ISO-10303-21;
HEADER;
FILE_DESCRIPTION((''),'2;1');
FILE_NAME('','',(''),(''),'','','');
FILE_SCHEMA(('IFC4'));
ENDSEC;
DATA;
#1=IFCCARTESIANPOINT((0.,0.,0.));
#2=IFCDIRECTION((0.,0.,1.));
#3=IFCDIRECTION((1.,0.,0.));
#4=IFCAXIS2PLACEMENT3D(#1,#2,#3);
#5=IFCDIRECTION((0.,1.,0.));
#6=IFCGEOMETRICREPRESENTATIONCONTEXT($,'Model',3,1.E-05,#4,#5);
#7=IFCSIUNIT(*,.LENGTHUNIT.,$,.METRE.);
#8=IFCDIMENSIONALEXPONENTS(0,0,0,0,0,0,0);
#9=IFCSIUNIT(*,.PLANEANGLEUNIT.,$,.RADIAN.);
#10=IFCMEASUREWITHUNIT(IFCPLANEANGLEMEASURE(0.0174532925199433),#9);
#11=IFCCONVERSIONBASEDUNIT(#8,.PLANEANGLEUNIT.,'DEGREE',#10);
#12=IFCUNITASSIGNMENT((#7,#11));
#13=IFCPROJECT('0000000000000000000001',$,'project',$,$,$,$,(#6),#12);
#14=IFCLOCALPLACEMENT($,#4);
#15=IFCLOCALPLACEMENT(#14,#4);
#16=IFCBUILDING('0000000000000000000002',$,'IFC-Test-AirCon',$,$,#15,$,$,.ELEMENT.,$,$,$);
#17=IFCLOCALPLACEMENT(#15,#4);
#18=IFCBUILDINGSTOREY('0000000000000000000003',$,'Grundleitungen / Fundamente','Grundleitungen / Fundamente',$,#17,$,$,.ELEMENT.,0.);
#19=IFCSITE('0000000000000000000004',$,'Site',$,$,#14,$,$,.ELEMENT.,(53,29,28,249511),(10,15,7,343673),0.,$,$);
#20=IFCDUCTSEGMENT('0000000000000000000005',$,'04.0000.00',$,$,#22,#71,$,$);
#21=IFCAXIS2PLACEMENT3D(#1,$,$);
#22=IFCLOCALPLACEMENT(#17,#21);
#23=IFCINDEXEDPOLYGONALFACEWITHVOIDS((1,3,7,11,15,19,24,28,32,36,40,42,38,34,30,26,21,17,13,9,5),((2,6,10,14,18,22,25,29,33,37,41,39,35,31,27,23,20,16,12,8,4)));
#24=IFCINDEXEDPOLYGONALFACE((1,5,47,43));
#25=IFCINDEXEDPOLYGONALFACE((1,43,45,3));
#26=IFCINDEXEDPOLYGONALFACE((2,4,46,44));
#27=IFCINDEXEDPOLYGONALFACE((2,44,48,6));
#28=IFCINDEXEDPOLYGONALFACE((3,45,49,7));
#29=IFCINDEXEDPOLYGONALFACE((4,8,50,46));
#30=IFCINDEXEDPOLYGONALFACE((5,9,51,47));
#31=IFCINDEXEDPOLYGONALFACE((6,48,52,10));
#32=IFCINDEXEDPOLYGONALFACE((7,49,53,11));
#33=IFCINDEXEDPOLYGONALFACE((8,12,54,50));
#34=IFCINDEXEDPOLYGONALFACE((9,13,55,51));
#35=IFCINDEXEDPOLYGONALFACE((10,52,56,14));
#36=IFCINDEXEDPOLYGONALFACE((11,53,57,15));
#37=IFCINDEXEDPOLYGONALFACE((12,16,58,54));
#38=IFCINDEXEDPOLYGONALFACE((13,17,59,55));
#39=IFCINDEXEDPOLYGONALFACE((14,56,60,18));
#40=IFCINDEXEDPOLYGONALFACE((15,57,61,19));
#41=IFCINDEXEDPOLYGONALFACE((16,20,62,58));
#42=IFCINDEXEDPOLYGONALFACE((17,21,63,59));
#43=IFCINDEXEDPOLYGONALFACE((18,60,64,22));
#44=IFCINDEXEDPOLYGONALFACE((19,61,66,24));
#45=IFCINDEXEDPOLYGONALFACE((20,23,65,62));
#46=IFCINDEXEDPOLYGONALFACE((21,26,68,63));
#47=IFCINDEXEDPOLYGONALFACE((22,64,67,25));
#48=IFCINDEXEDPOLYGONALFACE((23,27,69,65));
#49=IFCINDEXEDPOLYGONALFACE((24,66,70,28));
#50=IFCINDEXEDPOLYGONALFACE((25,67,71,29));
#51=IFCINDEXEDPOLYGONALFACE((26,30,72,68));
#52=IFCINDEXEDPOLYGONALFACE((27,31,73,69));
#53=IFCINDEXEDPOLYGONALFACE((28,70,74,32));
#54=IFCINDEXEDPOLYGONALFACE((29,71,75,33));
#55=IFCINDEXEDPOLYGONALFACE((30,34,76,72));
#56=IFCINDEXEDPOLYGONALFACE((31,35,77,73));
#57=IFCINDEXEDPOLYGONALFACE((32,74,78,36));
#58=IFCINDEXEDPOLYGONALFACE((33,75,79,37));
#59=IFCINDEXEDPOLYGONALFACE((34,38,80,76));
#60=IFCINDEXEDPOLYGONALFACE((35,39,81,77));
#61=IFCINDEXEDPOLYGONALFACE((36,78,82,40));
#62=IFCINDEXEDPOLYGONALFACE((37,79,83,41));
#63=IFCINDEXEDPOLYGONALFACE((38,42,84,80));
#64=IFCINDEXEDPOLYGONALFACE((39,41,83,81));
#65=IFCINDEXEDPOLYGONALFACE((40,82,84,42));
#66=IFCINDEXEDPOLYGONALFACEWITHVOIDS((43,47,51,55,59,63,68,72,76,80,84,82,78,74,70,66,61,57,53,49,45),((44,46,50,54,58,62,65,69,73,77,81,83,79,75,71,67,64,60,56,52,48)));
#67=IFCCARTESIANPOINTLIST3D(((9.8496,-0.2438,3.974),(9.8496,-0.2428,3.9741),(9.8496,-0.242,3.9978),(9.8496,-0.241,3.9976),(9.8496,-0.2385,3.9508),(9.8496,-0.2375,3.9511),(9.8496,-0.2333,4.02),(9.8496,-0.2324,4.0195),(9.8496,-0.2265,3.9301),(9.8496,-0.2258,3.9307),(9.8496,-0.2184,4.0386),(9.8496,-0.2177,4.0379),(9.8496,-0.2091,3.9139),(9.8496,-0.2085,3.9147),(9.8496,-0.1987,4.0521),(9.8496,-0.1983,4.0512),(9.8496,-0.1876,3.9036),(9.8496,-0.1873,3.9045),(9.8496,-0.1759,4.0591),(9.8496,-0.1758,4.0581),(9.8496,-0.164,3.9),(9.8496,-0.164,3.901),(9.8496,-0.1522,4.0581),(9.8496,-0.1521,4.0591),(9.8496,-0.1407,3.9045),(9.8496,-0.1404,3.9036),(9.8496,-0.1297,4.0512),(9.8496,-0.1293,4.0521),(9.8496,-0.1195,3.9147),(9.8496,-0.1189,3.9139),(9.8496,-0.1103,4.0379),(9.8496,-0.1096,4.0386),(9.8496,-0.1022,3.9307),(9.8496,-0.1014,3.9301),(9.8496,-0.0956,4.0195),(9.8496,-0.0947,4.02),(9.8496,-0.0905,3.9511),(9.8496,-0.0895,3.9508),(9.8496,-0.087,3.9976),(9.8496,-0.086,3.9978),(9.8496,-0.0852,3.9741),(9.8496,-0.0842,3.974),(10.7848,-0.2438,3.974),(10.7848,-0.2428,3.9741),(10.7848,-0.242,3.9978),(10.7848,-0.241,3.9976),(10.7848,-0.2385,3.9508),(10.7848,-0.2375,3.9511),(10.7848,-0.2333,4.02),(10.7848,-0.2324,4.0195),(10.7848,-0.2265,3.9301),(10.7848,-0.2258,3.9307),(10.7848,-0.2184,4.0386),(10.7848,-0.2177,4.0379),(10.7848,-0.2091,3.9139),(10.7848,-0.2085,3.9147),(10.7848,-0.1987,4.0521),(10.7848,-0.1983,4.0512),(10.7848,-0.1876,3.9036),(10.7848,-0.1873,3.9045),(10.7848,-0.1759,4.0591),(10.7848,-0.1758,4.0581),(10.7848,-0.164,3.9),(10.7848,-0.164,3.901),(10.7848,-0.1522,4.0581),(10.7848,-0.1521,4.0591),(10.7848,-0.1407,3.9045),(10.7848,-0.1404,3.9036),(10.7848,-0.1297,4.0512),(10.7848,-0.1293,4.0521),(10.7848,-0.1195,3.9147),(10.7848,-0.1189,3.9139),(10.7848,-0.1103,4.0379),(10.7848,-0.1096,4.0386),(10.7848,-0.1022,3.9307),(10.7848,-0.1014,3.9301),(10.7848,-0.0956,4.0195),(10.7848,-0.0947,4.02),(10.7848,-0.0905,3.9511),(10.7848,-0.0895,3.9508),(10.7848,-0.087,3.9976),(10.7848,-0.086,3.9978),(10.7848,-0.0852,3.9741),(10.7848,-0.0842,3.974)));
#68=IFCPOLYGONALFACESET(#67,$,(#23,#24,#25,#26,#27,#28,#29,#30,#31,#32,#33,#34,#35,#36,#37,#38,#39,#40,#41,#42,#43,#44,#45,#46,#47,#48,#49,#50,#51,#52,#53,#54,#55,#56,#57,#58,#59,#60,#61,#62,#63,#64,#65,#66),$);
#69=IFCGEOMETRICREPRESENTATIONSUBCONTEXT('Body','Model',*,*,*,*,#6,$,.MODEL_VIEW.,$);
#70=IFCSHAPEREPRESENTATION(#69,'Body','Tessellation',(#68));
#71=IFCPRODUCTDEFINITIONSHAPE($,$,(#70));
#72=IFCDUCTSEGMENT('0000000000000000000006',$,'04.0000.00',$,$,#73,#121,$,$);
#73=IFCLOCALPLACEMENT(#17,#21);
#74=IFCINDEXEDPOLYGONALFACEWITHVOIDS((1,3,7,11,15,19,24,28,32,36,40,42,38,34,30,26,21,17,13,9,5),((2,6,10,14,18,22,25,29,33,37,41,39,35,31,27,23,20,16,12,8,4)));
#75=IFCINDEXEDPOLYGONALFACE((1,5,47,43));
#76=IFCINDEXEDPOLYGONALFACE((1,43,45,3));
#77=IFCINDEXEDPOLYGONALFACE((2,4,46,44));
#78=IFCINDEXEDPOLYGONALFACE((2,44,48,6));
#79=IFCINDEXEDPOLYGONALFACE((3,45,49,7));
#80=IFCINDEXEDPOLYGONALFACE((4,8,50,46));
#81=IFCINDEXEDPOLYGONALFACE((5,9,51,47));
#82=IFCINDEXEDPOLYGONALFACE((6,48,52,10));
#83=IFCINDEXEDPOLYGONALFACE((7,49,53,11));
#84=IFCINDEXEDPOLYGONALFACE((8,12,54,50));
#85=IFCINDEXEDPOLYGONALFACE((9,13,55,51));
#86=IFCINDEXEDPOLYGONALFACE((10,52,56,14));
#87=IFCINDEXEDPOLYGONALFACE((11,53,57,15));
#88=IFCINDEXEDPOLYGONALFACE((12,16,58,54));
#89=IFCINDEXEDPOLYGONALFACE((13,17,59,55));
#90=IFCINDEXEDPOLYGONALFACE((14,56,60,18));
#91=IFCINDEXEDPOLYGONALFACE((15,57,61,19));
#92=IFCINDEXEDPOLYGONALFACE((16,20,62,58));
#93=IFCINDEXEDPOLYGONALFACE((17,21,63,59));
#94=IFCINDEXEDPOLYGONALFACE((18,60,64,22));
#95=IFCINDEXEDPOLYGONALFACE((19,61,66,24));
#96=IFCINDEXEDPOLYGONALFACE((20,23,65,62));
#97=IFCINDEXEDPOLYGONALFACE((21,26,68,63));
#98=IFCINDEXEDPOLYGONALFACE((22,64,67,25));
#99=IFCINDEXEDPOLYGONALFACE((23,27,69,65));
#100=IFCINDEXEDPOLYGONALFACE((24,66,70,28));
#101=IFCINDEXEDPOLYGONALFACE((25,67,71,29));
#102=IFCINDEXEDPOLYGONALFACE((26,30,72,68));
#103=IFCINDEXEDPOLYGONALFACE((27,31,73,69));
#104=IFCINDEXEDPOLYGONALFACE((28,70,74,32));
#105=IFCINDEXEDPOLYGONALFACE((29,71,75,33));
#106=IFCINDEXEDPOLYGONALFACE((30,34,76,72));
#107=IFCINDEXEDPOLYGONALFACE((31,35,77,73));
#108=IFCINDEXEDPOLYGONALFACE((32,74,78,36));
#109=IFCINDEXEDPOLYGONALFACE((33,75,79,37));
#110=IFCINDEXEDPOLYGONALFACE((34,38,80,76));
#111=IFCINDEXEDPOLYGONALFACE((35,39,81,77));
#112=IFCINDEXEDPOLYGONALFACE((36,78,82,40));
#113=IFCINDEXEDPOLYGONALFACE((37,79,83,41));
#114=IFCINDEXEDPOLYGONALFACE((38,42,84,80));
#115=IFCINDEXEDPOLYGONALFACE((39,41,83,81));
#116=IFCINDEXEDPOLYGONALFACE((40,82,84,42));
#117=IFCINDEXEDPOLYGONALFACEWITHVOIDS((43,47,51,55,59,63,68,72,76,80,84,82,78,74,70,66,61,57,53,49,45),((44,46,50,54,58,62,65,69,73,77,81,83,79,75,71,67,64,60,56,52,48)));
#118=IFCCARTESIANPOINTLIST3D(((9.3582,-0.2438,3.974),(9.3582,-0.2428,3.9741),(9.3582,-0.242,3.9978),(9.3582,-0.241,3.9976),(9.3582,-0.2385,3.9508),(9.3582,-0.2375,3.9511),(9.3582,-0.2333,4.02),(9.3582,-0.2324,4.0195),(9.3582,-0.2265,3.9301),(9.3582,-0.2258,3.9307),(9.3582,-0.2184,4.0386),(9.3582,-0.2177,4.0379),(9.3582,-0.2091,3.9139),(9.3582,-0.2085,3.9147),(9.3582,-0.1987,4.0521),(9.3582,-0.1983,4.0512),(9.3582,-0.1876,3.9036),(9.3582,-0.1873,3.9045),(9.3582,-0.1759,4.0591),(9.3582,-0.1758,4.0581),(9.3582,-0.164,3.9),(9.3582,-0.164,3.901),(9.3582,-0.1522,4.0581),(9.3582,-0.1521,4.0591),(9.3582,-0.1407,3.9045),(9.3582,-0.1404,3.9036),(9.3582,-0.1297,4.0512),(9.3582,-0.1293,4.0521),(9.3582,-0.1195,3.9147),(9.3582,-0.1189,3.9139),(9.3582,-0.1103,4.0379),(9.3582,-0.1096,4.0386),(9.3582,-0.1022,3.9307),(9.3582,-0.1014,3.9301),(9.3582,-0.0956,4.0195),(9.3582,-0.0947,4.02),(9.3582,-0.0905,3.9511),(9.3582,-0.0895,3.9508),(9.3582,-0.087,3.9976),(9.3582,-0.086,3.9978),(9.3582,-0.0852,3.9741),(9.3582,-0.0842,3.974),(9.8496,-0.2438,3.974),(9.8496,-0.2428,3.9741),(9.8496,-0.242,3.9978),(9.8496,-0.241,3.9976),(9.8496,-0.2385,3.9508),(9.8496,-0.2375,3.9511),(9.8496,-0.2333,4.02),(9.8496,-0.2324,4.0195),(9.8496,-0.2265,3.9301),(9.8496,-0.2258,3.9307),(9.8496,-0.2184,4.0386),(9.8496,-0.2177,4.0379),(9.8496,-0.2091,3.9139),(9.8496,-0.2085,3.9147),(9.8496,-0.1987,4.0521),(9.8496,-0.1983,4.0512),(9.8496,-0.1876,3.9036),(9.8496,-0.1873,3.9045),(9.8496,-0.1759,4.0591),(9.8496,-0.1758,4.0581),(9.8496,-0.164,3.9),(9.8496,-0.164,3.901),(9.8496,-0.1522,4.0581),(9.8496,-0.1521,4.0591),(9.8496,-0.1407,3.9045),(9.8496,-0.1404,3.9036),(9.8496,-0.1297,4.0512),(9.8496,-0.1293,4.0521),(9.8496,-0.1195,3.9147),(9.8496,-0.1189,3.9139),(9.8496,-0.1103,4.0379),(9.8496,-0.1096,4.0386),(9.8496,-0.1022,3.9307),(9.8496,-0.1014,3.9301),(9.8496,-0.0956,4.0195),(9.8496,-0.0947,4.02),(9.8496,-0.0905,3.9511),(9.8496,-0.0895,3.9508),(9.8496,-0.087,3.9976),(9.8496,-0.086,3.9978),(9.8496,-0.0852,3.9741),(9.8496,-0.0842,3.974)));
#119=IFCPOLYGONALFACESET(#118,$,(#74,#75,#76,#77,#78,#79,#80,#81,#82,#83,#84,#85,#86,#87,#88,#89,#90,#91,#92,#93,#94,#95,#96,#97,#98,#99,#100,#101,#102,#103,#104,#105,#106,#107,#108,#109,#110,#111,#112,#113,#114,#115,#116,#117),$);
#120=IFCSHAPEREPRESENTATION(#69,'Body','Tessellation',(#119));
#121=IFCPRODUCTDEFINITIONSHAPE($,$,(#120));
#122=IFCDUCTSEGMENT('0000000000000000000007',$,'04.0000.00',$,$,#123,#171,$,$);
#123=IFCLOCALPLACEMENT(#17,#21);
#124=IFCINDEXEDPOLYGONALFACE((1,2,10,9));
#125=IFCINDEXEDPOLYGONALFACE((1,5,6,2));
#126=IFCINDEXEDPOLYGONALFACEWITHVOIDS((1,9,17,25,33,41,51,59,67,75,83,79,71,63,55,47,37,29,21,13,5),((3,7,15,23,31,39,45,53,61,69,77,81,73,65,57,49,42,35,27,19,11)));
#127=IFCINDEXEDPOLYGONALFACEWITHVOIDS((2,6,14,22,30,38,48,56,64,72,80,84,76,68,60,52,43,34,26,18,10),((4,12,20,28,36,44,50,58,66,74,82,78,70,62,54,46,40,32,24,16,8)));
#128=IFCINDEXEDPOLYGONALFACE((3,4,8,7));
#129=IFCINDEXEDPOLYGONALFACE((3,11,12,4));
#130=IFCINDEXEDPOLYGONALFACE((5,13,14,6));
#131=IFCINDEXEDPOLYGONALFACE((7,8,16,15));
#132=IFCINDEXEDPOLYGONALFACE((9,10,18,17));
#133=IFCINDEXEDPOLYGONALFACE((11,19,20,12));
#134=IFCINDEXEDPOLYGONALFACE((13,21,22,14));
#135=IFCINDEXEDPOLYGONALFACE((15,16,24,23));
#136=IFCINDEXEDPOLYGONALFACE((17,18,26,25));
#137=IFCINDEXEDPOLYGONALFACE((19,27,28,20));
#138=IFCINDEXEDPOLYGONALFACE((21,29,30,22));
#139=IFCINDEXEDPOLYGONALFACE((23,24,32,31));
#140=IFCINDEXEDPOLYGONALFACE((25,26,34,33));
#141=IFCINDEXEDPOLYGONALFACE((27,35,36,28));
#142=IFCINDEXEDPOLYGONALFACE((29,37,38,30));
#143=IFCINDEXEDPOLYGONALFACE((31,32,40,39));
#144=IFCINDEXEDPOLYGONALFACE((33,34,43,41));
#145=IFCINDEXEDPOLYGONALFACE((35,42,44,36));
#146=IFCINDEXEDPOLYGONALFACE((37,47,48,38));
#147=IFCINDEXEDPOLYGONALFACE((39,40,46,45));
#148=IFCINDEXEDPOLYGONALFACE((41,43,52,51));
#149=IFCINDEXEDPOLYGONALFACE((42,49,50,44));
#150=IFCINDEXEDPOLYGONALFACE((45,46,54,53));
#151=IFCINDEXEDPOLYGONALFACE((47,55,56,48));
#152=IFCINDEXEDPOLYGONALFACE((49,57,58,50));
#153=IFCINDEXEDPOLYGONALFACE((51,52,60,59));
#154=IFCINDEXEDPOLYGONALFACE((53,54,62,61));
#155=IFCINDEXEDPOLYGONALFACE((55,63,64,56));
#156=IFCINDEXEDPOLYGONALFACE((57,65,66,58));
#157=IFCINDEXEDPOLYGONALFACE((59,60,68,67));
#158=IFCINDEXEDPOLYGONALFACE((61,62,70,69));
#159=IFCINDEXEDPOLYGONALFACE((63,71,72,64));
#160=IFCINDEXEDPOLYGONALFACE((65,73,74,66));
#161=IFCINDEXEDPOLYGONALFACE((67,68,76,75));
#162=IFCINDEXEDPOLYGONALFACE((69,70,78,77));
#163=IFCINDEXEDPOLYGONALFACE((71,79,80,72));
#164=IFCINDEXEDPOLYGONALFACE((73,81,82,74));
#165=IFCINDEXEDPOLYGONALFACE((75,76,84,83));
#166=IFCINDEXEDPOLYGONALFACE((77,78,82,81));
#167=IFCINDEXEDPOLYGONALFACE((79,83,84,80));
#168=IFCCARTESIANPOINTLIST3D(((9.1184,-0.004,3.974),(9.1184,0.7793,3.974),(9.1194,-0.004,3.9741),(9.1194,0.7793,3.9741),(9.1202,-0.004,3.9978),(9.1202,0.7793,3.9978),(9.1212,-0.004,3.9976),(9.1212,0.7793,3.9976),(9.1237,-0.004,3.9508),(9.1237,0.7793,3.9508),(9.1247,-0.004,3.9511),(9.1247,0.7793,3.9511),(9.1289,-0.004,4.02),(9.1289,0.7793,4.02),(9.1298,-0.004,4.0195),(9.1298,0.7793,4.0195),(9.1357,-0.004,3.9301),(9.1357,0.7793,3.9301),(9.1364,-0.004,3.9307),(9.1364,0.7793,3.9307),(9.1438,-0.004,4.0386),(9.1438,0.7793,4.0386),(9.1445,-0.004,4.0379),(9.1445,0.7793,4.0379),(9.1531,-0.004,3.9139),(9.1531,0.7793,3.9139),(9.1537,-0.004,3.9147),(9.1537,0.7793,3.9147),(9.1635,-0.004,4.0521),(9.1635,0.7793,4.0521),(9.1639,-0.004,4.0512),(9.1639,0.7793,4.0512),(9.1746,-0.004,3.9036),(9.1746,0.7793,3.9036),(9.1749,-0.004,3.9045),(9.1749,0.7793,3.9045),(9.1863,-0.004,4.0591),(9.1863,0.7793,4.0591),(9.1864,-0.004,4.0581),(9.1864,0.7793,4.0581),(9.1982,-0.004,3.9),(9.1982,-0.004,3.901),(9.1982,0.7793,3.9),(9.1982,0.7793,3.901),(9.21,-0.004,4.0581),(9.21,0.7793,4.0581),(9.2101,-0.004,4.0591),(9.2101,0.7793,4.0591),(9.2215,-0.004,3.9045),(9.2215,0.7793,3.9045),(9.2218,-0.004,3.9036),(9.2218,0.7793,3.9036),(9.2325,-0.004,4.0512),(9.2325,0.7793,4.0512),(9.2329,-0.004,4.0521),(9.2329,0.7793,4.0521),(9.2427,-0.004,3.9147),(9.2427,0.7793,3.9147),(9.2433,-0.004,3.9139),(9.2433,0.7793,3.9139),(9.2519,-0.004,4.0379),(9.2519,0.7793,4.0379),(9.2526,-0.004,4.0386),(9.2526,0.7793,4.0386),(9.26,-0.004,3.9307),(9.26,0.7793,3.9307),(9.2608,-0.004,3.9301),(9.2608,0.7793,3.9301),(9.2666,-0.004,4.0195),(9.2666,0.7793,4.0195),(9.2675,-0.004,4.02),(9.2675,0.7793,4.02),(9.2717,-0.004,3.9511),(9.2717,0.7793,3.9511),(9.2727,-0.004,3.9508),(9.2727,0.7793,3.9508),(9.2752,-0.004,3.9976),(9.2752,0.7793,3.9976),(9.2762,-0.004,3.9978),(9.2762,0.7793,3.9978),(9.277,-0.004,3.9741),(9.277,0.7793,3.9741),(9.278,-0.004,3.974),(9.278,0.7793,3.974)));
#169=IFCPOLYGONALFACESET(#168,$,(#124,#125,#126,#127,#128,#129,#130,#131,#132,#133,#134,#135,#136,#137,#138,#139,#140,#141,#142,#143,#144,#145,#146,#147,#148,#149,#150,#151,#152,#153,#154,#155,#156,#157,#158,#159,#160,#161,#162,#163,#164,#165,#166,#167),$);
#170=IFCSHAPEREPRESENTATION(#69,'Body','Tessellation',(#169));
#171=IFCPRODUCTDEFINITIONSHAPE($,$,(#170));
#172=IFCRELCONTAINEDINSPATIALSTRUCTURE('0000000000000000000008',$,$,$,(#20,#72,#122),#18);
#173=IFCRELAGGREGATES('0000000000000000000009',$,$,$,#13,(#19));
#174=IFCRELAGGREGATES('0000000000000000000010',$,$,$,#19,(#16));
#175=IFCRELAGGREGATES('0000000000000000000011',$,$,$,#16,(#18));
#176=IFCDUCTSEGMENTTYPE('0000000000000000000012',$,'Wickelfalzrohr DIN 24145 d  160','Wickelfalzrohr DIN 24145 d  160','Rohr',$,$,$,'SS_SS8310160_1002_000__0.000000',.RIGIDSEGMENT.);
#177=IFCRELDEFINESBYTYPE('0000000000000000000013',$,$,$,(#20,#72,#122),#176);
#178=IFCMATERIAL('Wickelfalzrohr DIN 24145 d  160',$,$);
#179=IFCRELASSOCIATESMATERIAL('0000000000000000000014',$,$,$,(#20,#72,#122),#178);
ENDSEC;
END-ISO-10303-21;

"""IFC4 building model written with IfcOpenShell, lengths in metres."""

from ifc_helpers import new_model, entity, si_unit, converted_unit, direction, frame, origin_with_axes, origin_2d_with_axis, place, context, subcontext, project, spatial, hollow_circle, extrude, material, type_object, element, save


model = new_model("IFC4")

# Units and contexts
model_context = context("Model", 3, precision=1e-05, world=origin_with_axes(), true_north=direction((0.0, 1.0, 0.0)))
body_context = subcontext(model_context, "Body", "Model", "MODEL_VIEW")
ifc_project = project(units=[si_unit("LENGTHUNIT", "METRE"), converted_unit("PLANEANGLEUNIT", "DEGREE", entity("IfcPlaneAngleMeasure", 0.0174532925199433), si_unit("PLANEANGLEUNIT", "RADIAN"), dimensions=[0, 0, 0, 0, 0, 0, 0])], contexts=[model_context])

# Site, building, storey
site_placement = place(None, origin_with_axes())
site = spatial("IfcSite", under=ifc_project, at=site_placement, Name="Site", CompositionType="ELEMENT", RefLatitude=(53, 29, 28, 249511), RefLongitude=(10, 15, 7, 343673), RefElevation=0.0)
building_placement = place(site_placement, origin_with_axes())
building = spatial("IfcBuilding", under=site, at=building_placement, Name="IFC-Test-AirCon", CompositionType="ELEMENT")
storey_placement = place(building_placement, origin_with_axes())
storey = spatial("IfcBuildingStorey", under=building, at=storey_placement, Name="Grundleitungen / Fundamente", Description="Grundleitungen / Fundamente", CompositionType="ELEMENT", Elevation=0.0)

# Duct segments
ifc_material_1 = material(Name="Wickelfalzrohr DIN 24145 d  160")
duct_segment_type_1 = type_object("IfcDuctSegmentType", Name="Wickelfalzrohr DIN 24145 d  160", Description="Wickelfalzrohr DIN 24145 d  160", ApplicableOccurrence="Rohr", ElementType="SS_SS8310160_1002_000__0.000000", PredefinedType="RIGIDSEGMENT")
duct_segment_1_placement = place(storey_placement, frame((10.7848, -0.164, 3.98), z_axis=(0.0, 0.0, 1.0), x_axis=(-1.0, 0.0, 0.0)))
element("IfcDuctSegment", 1, at=duct_segment_1_placement, inside=storey, type_object=duct_segment_type_1, material=ifc_material_1, Name="04.0000.00", context=body_context, shape_type="SweptSolid", body=[
    extrude(hollow_circle(Radius=0.08, WallThickness=0.001, at=origin_2d_with_axis()), frame((0.0, 0.0, 0.0), z_axis=(1.0, 0.0, 0.0), x_axis=(0.0, 0.0, -1.0)), (0.0, 0.0, 1.0), 0.9351),
])
duct_segment_2_placement = place(storey_placement, frame((9.8496, -0.164, 3.98), z_axis=(0.0, 0.0, 1.0), x_axis=(-1.0, 0.0, 0.0)))
element("IfcDuctSegment", 2, at=duct_segment_2_placement, inside=storey, type_object=duct_segment_type_1, material=ifc_material_1, Name="04.0000.00", context=body_context, shape_type="SweptSolid", body=[
    extrude(hollow_circle(Radius=0.08, WallThickness=0.001, at=origin_2d_with_axis()), frame((0.0, 0.0, 0.0), z_axis=(1.0, 0.0, 0.0), x_axis=(0.0, 0.0, -1.0)), (0.0, 0.0, 1.0), 0.4914),
])
duct_segment_3_placement = place(storey_placement, frame((9.1982, -0.004, 3.98), z_axis=(0.0, 0.0, 1.0), x_axis=(0.0, 1.0, 0.0)))
element("IfcDuctSegment", 3, at=duct_segment_3_placement, inside=storey, type_object=duct_segment_type_1, material=ifc_material_1, Name="04.0000.00", context=body_context, shape_type="SweptSolid", body=[
    extrude(hollow_circle(Radius=0.08, WallThickness=0.001, at=origin_2d_with_axis()), frame((0.0, 0.0, 0.0), z_axis=(1.0, 0.0, 0.0), x_axis=(0.0, 0.0, -1.0)), (0.0, 0.0, 1.0), 0.7833),
])

save(model, "model.ifc")
